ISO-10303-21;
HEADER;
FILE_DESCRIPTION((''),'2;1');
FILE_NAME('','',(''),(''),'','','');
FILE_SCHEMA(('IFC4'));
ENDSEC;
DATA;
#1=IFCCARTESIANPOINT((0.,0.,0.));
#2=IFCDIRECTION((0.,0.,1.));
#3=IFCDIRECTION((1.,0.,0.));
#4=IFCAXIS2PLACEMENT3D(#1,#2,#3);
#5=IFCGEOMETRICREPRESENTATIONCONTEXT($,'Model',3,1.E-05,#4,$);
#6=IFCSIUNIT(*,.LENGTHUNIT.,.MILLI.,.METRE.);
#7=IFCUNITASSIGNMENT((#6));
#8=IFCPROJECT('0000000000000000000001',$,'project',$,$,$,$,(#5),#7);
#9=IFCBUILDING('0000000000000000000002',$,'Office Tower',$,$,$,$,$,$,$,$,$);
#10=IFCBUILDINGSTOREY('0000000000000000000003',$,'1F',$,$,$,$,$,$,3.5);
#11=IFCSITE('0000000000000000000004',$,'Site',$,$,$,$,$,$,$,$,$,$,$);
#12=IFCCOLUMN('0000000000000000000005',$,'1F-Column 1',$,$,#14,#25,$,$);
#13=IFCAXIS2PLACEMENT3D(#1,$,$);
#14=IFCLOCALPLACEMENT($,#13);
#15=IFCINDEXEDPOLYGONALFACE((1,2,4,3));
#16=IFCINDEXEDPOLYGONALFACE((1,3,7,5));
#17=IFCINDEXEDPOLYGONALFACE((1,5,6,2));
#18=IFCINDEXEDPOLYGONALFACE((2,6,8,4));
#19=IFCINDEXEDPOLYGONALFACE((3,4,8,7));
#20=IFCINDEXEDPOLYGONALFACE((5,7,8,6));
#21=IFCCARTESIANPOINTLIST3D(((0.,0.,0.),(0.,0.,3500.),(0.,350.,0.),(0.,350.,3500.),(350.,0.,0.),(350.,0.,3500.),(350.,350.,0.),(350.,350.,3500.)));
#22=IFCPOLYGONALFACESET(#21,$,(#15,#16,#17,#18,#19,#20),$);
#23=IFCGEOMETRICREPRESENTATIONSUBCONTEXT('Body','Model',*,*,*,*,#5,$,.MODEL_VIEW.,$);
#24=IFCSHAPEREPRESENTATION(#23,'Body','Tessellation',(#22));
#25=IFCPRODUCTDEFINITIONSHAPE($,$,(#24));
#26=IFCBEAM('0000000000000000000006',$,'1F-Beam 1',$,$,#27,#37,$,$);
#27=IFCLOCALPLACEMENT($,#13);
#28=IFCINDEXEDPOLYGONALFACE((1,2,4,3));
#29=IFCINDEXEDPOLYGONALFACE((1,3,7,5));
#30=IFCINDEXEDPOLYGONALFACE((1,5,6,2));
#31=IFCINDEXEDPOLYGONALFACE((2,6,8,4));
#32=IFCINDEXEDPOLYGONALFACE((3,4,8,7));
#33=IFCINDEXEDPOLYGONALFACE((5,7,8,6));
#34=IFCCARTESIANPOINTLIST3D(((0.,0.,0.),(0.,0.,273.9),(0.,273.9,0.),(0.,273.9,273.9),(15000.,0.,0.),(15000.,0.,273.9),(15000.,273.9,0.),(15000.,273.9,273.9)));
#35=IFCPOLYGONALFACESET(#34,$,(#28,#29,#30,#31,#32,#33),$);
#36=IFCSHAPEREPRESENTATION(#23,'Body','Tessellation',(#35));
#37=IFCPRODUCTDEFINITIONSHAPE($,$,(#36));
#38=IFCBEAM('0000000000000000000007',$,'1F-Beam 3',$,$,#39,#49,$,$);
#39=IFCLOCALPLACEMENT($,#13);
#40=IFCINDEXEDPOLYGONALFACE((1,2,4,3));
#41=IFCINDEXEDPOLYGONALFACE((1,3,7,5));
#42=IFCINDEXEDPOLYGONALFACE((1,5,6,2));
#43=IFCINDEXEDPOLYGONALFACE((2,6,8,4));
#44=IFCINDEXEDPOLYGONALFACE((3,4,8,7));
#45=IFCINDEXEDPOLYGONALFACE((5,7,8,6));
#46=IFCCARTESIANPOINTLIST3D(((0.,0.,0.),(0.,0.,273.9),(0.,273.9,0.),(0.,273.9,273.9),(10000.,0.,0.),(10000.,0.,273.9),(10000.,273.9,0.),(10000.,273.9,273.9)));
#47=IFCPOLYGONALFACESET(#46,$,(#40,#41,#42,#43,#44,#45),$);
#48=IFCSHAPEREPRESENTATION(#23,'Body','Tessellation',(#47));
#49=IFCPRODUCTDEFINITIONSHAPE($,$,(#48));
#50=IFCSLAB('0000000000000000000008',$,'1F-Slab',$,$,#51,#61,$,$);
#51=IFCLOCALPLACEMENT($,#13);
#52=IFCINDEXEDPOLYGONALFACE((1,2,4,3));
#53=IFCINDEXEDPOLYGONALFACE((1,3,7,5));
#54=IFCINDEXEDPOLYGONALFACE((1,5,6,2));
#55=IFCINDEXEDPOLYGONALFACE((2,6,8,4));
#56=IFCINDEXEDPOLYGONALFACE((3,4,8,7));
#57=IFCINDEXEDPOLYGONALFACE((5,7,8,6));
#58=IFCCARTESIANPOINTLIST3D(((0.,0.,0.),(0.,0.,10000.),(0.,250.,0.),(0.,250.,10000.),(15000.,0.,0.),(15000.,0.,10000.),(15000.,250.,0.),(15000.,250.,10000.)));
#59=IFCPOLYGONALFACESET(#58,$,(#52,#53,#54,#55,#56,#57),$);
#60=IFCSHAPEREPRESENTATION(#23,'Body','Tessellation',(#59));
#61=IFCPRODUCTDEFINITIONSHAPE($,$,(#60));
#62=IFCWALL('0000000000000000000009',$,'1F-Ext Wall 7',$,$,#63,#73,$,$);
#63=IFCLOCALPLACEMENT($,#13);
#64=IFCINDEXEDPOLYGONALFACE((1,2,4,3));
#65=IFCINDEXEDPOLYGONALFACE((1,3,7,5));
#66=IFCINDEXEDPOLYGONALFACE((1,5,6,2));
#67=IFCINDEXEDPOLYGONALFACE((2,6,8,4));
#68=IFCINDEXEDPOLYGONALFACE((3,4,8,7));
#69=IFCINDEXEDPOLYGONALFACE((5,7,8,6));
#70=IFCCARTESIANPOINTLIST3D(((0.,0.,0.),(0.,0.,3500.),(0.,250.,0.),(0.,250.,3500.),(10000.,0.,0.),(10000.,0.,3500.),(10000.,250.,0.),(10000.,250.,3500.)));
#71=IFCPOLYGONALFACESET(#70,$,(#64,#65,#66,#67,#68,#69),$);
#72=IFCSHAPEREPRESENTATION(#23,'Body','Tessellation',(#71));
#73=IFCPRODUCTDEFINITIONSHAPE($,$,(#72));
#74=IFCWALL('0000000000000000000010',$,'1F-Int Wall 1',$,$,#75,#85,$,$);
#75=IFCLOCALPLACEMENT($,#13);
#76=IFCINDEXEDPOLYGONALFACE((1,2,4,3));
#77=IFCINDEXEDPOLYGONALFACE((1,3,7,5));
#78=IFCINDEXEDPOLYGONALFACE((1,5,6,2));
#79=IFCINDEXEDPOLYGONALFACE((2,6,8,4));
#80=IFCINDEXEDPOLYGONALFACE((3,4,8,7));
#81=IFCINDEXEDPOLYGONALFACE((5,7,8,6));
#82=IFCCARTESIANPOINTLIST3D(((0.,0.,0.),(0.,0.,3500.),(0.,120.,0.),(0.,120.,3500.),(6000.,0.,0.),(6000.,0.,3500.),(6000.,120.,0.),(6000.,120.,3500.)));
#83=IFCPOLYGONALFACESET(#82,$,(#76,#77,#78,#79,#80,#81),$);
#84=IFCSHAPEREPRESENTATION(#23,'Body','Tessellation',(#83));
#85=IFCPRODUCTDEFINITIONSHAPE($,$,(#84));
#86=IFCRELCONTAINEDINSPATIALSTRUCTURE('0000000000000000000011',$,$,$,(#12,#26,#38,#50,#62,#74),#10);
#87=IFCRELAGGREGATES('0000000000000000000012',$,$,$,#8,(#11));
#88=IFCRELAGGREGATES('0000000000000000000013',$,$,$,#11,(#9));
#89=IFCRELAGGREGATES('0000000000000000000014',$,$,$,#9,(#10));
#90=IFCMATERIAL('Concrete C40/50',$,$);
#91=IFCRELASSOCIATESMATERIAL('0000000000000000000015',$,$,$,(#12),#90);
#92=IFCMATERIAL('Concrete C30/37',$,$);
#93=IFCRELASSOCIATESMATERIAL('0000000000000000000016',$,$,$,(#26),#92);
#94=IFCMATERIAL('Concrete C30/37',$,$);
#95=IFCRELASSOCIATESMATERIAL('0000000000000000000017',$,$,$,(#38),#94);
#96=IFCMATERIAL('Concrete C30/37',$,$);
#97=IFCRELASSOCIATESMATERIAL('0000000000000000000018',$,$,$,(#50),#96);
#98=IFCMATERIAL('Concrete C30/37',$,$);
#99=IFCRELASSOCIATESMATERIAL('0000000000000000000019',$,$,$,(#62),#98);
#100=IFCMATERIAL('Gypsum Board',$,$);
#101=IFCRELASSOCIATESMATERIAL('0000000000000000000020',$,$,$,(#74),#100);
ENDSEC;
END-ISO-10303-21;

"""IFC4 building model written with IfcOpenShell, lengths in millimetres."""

from ifc_helpers import new_model, si_unit, origin_with_axes, context, subcontext, project, spatial, indexed_curve, outline, extrude, material, element, save


model = new_model("IFC4")

# Units and contexts
model_context = context("Model", 3, precision=1e-05, world=origin_with_axes())
body_context = subcontext(model_context, "Body", "Model", "MODEL_VIEW")
ifc_project = project(units=[si_unit("LENGTHUNIT", "METRE", prefix="MILLI")], contexts=[model_context])

# Site, building, storey
site = spatial("IfcSite", under=ifc_project, Name="Site")
building = spatial("IfcBuilding", under=site, Name="Office Tower")
storey = spatial("IfcBuildingStorey", under=building, Name="1F", Elevation=3.5)

# Column
ifc_material_1 = material(Name="Concrete C40/50")
element("IfcColumn", 1, inside=storey, material=ifc_material_1, Name="1F-Column 1", context=body_context, shape_type="SweptSolid", body=[
    extrude(outline(indexed_curve([(0.0, 0.0), (0.0, 350.0), (350.0, 350.0), (350.0, 0.0), (0.0, 0.0)], self_intersect=False)), origin_with_axes(), (0.0, 0.0, 1.0), 3500.0),
])

# Beams
ifc_material_2 = material(Name="Concrete C30/37")
element("IfcBeam", 2, inside=storey, material=ifc_material_2, Name="1F-Beam 1", context=body_context, shape_type="SweptSolid", body=[
    extrude(outline(indexed_curve([(0.0, 0.0), (0.0, 273.9), (15000.0, 273.9), (15000.0, 0.0), (0.0, 0.0)], self_intersect=False)), origin_with_axes(), (0.0, 0.0, 1.0), 273.9),
])
ifc_material_3 = material(Name="Concrete C30/37")
element("IfcBeam", 3, inside=storey, material=ifc_material_3, Name="1F-Beam 3", context=body_context, shape_type="SweptSolid", body=[
    extrude(outline(indexed_curve([(0.0, 0.0), (0.0, 273.9), (10000.0, 273.9), (10000.0, 0.0), (0.0, 0.0)], self_intersect=False)), origin_with_axes(), (0.0, 0.0, 1.0), 273.9),
])

# Slab
ifc_material_4 = material(Name="Concrete C30/37")
element("IfcSlab", 4, inside=storey, material=ifc_material_4, Name="1F-Slab", context=body_context, shape_type="SweptSolid", body=[
    extrude(outline(indexed_curve([(0.0, 0.0), (0.0, 250.0), (15000.0, 250.0), (15000.0, 0.0), (0.0, 0.0)], self_intersect=False)), origin_with_axes(), (0.0, 0.0, 1.0), 10000.0),
])

# Walls
ifc_material_5 = material(Name="Concrete C30/37")
element("IfcWall", 5, inside=storey, material=ifc_material_5, Name="1F-Ext Wall 7", context=body_context, shape_type="SweptSolid", body=[
    extrude(outline(indexed_curve([(0.0, 0.0), (0.0, 250.0), (10000.0, 250.0), (10000.0, 0.0), (0.0, 0.0)], self_intersect=False)), origin_with_axes(), (0.0, 0.0, 1.0), 3500.0),
])
ifc_material_6 = material(Name="Gypsum Board")
element("IfcWall", 6, inside=storey, material=ifc_material_6, Name="1F-Int Wall 1", context=body_context, shape_type="SweptSolid", body=[
    extrude(outline(indexed_curve([(0.0, 0.0), (0.0, 120.0), (6000.0, 120.0), (6000.0, 0.0), (0.0, 0.0)], self_intersect=False)), origin_with_axes(), (0.0, 0.0, 1.0), 3500.0),
])

save(model, "model.ifc")
